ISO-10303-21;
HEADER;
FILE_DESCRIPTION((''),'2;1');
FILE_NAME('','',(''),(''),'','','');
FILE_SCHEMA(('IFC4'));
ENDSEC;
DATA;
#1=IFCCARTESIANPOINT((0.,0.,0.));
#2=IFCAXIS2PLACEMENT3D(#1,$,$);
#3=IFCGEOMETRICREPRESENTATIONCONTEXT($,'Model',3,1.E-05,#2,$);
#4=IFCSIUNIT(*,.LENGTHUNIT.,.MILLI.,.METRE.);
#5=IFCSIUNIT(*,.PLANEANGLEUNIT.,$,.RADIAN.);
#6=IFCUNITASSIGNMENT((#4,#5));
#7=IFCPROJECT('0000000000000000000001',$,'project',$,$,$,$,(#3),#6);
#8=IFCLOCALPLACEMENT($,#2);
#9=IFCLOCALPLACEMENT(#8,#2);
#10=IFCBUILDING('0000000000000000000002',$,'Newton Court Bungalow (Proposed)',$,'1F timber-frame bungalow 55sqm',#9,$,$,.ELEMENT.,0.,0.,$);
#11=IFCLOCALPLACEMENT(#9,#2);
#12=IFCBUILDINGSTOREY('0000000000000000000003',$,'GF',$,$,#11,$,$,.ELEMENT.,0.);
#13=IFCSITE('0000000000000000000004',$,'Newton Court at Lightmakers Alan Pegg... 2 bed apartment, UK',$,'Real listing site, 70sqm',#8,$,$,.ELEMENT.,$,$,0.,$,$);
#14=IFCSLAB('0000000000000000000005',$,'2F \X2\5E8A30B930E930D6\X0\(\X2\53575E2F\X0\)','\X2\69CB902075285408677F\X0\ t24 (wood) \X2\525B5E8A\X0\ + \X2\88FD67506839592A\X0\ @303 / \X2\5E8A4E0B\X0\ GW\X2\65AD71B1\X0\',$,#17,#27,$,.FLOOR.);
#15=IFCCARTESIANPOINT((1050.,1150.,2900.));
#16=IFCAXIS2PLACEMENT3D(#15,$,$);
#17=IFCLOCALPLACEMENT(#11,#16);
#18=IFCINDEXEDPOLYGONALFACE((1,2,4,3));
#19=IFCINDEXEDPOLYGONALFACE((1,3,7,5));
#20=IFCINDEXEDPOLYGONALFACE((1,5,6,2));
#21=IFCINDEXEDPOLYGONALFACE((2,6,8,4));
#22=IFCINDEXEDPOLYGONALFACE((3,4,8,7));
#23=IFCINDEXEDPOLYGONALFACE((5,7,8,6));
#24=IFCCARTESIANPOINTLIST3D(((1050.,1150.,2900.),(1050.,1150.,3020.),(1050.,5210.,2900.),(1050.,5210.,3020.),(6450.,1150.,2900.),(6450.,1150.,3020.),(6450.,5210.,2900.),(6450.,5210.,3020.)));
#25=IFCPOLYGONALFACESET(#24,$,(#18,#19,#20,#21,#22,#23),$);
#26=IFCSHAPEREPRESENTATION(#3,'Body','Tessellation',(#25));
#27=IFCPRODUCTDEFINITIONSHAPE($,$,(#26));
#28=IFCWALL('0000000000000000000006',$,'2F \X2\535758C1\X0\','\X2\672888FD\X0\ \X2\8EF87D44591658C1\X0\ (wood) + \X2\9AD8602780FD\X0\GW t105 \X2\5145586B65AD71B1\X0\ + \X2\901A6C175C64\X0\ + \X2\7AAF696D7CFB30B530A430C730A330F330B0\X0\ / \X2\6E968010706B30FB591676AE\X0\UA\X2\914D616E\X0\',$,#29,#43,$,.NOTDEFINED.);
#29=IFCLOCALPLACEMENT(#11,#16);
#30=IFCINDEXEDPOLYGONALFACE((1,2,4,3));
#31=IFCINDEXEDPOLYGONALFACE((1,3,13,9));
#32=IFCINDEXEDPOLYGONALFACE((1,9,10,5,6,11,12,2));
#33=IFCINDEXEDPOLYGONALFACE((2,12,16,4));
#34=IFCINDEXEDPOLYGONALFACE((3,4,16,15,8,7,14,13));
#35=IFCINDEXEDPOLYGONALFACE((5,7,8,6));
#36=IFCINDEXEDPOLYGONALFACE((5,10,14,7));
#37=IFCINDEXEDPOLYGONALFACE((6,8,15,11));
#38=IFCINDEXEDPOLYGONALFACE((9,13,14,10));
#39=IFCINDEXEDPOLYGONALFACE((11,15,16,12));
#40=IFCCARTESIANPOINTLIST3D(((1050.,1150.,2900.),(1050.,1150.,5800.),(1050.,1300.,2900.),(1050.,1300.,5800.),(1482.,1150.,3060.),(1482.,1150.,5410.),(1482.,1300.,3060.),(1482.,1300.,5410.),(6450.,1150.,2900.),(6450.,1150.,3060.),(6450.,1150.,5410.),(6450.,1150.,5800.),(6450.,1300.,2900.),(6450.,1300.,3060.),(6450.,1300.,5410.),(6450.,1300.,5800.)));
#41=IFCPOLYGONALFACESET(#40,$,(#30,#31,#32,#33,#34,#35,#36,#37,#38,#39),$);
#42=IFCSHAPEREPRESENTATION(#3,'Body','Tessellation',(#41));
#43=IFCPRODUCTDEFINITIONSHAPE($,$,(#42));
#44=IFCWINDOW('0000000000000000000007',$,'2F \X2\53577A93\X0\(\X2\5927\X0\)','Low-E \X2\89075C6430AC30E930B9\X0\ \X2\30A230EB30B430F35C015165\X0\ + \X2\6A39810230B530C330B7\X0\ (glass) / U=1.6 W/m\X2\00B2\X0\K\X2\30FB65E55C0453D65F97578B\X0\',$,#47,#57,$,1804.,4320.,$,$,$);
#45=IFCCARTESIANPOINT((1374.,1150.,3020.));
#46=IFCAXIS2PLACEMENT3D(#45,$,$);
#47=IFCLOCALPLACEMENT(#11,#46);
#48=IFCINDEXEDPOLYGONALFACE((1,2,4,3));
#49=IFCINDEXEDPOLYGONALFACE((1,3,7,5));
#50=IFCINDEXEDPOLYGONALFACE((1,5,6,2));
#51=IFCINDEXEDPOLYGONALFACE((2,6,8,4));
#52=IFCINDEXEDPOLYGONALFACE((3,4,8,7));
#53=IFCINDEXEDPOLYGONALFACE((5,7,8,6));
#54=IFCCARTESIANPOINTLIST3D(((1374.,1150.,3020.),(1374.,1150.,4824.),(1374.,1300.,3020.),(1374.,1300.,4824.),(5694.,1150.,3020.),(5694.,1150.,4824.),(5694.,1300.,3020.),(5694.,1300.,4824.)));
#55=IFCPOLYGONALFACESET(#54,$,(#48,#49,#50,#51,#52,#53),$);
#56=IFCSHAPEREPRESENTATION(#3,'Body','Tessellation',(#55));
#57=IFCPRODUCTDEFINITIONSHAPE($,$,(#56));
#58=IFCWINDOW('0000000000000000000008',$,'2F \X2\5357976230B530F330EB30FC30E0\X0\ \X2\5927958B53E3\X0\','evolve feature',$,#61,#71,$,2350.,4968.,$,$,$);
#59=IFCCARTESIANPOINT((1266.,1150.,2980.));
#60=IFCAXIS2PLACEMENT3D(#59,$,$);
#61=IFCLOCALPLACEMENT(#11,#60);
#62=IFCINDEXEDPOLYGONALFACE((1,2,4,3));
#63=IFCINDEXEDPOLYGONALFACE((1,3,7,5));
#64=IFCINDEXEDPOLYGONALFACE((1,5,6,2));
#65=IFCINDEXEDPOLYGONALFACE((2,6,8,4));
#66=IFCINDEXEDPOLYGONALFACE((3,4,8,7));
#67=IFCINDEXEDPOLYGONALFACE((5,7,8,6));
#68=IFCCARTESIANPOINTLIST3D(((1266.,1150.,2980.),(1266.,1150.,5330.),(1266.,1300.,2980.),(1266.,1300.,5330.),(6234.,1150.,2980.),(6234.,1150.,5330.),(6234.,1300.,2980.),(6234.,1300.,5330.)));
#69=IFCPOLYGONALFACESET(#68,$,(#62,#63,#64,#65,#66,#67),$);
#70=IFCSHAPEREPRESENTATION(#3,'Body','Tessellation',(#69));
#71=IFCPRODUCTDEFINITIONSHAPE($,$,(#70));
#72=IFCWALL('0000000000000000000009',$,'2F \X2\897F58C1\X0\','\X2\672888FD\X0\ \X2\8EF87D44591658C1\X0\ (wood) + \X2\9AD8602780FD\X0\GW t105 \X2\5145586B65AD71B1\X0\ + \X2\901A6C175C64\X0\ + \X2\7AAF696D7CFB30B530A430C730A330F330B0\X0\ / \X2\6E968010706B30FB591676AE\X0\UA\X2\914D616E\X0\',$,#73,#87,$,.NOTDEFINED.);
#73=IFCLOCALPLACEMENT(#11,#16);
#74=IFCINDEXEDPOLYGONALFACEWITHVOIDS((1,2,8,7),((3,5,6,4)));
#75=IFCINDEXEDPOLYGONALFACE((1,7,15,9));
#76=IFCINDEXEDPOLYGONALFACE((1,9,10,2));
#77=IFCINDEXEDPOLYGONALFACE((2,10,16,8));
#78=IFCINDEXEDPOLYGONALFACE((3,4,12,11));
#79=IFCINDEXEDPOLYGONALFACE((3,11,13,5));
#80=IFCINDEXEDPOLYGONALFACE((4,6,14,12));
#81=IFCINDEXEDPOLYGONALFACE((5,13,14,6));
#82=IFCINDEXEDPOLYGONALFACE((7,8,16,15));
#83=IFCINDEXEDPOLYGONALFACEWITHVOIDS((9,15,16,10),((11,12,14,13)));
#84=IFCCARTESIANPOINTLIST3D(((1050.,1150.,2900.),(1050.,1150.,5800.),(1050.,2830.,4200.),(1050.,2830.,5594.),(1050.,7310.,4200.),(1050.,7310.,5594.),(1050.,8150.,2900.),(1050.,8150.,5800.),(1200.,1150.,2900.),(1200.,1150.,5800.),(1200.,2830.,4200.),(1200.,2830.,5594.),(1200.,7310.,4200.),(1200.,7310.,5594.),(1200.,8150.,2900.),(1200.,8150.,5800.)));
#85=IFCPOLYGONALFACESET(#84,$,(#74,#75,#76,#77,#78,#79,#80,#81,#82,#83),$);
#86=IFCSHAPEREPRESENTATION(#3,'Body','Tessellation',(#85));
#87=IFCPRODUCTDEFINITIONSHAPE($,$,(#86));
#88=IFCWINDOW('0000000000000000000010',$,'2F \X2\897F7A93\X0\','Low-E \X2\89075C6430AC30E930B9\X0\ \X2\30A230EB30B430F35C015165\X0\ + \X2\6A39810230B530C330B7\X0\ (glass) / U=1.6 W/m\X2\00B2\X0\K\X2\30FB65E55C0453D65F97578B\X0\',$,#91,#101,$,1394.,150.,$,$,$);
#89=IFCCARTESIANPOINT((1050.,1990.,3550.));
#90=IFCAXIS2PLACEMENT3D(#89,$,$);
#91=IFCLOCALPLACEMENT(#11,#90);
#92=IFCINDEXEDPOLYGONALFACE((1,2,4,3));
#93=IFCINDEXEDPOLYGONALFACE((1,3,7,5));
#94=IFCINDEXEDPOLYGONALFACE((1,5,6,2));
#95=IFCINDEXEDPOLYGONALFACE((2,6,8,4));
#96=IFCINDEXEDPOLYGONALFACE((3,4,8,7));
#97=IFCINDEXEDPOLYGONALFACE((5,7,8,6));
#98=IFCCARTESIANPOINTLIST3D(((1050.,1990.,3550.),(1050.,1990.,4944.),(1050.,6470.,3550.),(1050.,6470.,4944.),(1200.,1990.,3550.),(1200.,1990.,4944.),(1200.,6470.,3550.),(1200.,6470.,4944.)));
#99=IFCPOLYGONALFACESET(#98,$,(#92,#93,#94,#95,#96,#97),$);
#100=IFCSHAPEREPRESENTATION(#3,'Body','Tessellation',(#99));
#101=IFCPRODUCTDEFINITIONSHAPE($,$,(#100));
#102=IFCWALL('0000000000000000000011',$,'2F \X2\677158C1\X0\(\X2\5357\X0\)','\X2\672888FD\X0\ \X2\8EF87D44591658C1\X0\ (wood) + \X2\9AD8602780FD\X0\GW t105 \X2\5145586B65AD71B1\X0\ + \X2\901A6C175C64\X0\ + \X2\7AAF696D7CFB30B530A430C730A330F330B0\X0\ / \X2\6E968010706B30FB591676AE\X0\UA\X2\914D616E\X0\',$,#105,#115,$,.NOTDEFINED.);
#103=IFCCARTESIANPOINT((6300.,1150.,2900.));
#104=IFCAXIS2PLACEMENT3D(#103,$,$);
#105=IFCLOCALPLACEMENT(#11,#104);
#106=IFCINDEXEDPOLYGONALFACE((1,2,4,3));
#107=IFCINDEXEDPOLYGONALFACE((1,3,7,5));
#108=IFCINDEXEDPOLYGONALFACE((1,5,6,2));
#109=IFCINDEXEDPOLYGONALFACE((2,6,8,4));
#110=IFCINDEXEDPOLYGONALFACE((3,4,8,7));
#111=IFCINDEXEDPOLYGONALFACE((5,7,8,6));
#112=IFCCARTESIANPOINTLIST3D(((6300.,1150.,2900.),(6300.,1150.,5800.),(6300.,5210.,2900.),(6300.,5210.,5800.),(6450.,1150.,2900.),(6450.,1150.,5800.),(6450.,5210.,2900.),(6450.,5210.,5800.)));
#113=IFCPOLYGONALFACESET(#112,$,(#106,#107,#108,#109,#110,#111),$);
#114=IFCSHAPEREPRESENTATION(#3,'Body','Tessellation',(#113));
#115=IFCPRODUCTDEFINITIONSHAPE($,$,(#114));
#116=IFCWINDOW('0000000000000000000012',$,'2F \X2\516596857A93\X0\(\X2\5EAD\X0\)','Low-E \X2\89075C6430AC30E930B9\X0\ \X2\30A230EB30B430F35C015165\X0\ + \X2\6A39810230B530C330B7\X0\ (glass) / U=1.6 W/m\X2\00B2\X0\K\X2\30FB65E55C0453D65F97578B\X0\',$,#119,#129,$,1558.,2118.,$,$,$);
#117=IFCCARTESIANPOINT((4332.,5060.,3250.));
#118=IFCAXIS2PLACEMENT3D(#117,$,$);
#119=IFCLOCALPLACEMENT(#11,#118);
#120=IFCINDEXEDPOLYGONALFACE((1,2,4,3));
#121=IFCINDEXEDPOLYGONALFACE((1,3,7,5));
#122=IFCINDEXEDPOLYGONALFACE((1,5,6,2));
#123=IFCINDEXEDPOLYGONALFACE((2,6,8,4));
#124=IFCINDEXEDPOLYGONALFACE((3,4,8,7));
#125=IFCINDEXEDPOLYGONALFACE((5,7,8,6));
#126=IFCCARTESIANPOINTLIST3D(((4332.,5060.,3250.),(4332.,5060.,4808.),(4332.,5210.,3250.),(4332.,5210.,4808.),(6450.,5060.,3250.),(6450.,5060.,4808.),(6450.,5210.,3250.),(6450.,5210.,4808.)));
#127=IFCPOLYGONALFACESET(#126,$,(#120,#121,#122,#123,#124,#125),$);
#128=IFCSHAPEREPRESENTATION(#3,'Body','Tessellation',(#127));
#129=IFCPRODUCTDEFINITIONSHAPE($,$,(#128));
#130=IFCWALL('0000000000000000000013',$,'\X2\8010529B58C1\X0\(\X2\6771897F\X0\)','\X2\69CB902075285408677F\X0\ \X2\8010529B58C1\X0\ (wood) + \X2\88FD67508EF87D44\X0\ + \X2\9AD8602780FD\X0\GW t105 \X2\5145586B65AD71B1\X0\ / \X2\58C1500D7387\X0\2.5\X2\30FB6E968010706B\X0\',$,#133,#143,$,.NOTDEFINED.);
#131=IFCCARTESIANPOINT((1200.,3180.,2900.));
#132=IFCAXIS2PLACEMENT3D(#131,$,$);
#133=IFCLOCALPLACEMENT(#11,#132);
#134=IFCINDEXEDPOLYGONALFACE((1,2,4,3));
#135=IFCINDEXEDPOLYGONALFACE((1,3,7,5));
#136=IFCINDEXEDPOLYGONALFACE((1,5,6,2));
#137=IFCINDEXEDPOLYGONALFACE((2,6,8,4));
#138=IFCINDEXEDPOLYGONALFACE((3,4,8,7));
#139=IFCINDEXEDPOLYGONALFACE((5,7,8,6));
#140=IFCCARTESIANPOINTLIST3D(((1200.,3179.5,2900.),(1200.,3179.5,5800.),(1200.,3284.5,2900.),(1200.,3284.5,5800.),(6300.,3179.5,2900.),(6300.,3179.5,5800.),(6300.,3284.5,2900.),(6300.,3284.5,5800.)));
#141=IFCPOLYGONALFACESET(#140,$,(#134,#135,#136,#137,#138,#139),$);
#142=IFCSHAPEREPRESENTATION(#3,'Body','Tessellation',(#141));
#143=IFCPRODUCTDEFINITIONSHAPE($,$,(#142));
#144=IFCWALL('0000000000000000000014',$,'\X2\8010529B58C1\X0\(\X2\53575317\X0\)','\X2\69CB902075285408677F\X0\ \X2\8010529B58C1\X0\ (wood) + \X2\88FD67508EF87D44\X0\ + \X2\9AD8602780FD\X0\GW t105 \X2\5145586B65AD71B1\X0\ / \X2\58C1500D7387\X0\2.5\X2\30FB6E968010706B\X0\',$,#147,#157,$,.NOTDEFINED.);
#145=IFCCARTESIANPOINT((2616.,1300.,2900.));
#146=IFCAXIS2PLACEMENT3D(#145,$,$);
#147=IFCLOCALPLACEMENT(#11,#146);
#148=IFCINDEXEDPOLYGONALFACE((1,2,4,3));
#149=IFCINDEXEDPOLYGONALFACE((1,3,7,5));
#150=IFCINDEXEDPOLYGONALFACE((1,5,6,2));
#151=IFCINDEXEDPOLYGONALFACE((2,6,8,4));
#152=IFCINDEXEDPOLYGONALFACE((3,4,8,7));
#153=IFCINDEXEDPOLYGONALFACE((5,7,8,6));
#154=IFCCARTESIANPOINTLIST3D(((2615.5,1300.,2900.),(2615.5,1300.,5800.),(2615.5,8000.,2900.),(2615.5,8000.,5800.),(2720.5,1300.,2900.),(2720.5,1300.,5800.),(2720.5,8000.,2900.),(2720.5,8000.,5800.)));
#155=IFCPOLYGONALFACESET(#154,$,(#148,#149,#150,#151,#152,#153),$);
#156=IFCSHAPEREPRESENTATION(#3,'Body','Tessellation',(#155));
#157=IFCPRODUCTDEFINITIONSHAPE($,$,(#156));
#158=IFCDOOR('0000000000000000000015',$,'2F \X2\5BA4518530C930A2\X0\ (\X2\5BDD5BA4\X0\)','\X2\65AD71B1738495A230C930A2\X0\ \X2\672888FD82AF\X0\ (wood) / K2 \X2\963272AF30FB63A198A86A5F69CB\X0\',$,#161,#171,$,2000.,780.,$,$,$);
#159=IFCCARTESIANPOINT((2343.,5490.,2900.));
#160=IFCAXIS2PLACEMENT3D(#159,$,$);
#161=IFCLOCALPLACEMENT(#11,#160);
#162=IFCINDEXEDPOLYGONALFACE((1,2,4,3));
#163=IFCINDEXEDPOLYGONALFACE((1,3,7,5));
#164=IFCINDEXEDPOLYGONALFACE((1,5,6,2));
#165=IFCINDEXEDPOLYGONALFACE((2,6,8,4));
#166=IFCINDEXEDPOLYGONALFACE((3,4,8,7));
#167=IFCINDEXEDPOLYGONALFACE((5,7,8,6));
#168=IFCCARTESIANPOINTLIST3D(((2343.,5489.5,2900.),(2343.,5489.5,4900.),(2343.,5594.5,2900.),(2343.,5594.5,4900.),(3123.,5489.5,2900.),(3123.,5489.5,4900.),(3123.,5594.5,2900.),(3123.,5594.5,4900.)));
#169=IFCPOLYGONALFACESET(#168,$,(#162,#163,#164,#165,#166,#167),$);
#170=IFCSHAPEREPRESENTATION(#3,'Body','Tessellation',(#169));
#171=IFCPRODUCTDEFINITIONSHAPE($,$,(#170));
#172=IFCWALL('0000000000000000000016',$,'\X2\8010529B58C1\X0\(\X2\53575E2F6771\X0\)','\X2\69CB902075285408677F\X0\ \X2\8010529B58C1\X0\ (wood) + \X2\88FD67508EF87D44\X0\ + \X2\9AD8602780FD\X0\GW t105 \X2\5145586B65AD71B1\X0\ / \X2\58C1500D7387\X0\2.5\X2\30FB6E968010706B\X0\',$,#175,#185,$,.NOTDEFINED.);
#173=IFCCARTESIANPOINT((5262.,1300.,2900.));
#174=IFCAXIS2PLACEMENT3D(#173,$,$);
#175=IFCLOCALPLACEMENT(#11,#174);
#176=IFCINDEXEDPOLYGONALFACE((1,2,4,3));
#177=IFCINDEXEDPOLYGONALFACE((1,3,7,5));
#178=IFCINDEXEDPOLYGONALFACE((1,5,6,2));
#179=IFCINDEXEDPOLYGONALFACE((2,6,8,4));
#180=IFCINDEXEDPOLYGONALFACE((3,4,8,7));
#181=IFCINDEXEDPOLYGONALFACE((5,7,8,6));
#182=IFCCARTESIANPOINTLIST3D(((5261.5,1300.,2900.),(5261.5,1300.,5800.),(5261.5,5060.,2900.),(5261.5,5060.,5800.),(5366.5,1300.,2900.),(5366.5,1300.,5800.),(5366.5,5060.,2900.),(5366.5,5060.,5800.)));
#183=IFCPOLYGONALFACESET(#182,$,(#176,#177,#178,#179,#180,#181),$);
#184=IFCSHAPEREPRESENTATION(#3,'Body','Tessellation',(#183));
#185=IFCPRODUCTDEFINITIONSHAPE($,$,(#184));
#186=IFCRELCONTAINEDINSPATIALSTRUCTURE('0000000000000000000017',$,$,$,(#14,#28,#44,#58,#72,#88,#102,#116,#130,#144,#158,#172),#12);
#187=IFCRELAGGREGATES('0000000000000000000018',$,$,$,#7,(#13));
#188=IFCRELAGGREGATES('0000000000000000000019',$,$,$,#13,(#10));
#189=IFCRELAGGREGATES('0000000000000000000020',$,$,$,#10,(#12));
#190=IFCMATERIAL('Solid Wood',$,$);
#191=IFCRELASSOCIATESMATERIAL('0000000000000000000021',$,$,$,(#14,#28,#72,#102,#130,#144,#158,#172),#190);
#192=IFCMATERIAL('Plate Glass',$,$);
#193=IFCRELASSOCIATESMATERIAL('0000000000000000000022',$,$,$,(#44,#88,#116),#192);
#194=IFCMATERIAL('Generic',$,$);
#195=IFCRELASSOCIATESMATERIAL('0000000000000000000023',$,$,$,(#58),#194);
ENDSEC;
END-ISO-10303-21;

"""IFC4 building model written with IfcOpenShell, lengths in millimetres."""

from ifc_helpers import new_model, si_unit, frame, frame_2d, origin, place, context, project, spatial, rectangle, extrude, material, element, fill, save


model = new_model("IFC4")

# Units and contexts
model_context = context("Model", 3, precision=1e-05, world=origin())
ifc_project = project(units=[si_unit("LENGTHUNIT", "METRE", prefix="MILLI"), si_unit("PLANEANGLEUNIT", "RADIAN")], contexts=[model_context])

# Site, building, storey
site_placement = place(None, origin())
site = spatial("IfcSite", under=ifc_project, at=site_placement, Name="Newton Court at Lightmakers Alan Pegg... 2 bed apartment, UK", ObjectType="Real listing site, 70sqm", CompositionType="ELEMENT", RefElevation=0.0)
building_placement = place(site_placement, origin())
building = spatial("IfcBuilding", under=site, at=building_placement, Name="Newton Court Bungalow (Proposed)", ObjectType="1F timber-frame bungalow 55sqm", CompositionType="ELEMENT", ElevationOfRefHeight=0.0, ElevationOfTerrain=0.0)
storey_placement = place(building_placement, origin())
storey = spatial("IfcBuildingStorey", under=building, at=storey_placement, Name="GF", CompositionType="ELEMENT", Elevation=0.0)

# Slab
ifc_material_1 = material(Name="Solid Wood")
slab_placement = place(storey_placement, frame((1050.0, 1150.0, 2900.0)))
element("IfcSlab", 1, at=slab_placement, inside=storey, material=ifc_material_1, Name="2F 床スラブ(南帯)", Description="構造用合板 t24 (wood) 剛床 + 製材根太 @303 / 床下 GW断熱", PredefinedType="FLOOR", context=model_context, shape_type="SweptSolid", body=[
    extrude(rectangle(XDim=5400.0, YDim=4060.0, at=frame_2d((2700.0, 2030.0))), frame((1050.0, 1150.0, 2900.0)), (0.0, 0.0, 1.0), 120.0),
])

# Wall, openings, windows
wall_1_placement = place(storey_placement, frame((1050.0, 1150.0, 2900.0)))
wall_1 = element("IfcWall", 2, at=wall_1_placement, inside=storey, material=ifc_material_1, Name="2F 南壁", Description="木製 軸組外壁 (wood) + 高性能GW t105 充填断熱 + 通気層 + 窯業系サイディング / 準耐火・外皮UA配慮", PredefinedType="NOTDEFINED", context=model_context, shape_type="SweptSolid", body=[
    extrude(rectangle(XDim=5400.0, YDim=150.0, at=frame_2d((2700.0, 75.0))), frame((1050.0, 1150.0, 2900.0)), (0.0, 0.0, 1.0), 2900.0),
])
opening_1_placement = place(storey_placement, frame((1374.0, 1150.0, 3020.0)))
opening_1 = element("IfcOpeningElement", 3, at=opening_1_placement, cuts=wall_1, PredefinedType="NOTDEFINED", context=model_context, shape_type="SweptSolid", body=[
    extrude(rectangle(XDim=4320.0, YDim=150.0, at=frame_2d((2160.0, 75.0))), frame((1374.0, 1150.0, 3020.0)), (0.0, 0.0, 1.0), 1804.0),
])
opening_2_placement = place(storey_placement, frame((1266.0, 1150.0, 2980.0)))
opening_2 = element("IfcOpeningElement", 4, at=opening_2_placement, cuts=wall_1, PredefinedType="NOTDEFINED", context=model_context, shape_type="SweptSolid", body=[
    extrude(rectangle(XDim=4968.0, YDim=150.0, at=frame_2d((2484.0, 75.0))), frame((1266.0, 1150.0, 2980.0)), (0.0, 0.0, 1.0), 2350.0),
])
ifc_material_2 = material(Name="Plate Glass")
window_1_placement = place(storey_placement, frame((1374.0, 1150.0, 3020.0)))
window_1 = element("IfcWindow", 5, at=window_1_placement, inside=storey, material=ifc_material_2, Name="2F 南窓(大)", Description="Low-E 複層ガラス アルゴン封入 + 樹脂サッシ (glass) / U=1.6 W/m²K・日射取得型", OverallHeight=1804.0, OverallWidth=4320.0, context=model_context, shape_type="SweptSolid", body=[
    extrude(rectangle(XDim=4320.0, YDim=150.0, at=frame_2d((2160.0, 75.0))), frame((1374.0, 1150.0, 3020.0)), (0.0, 0.0, 1.0), 1804.0),
])
fill(opening_1, window_1)
ifc_material_3 = material(Name="Generic")
window_2_placement = place(storey_placement, frame((1266.0, 1150.0, 2980.0)))
window_2 = element("IfcWindow", 6, at=window_2_placement, inside=storey, material=ifc_material_3, Name="2F 南面サンルーム 大開口", Description="evolve feature", OverallHeight=2350.0, OverallWidth=4968.0, context=model_context, shape_type="SweptSolid", body=[
    extrude(rectangle(XDim=4968.0, YDim=150.0, at=frame_2d((2484.0, 75.0))), frame((1266.0, 1150.0, 2980.0)), (0.0, 0.0, 1.0), 2350.0),
])
fill(opening_2, window_2)

# Walls, openings, windows
wall_2_placement = place(storey_placement, frame((1050.0, 1150.0, 2900.0)))
wall_2 = element("IfcWall", 7, at=wall_2_placement, inside=storey, material=ifc_material_1, Name="2F 西壁", Description="木製 軸組外壁 (wood) + 高性能GW t105 充填断熱 + 通気層 + 窯業系サイディング / 準耐火・外皮UA配慮", PredefinedType="NOTDEFINED", context=model_context, shape_type="SweptSolid", body=[
    extrude(rectangle(XDim=150.0, YDim=7000.0, at=frame_2d((75.0, 3500.0))), frame((1050.0, 1150.0, 2900.0)), (0.0, 0.0, 1.0), 2900.0),
])
opening_3_placement = place(storey_placement, frame((1050.0, 1990.0, 3550.0)))
opening_3 = element("IfcOpeningElement", 8, at=opening_3_placement, cuts=wall_2, PredefinedType="NOTDEFINED", context=model_context, shape_type="SweptSolid", body=[
    extrude(rectangle(XDim=150.0, YDim=4480.0, at=frame_2d((75.0, 2240.0))), frame((1050.0, 1990.0, 3550.0)), (0.0, 0.0, 1.0), 1394.0),
])
window_3_placement = place(storey_placement, frame((1050.0, 1990.0, 3550.0)))
window_3 = element("IfcWindow", 9, at=window_3_placement, inside=storey, material=ifc_material_2, Name="2F 西窓", Description="Low-E 複層ガラス アルゴン封入 + 樹脂サッシ (glass) / U=1.6 W/m²K・日射取得型", OverallHeight=1394.0, OverallWidth=150.0, context=model_context, shape_type="SweptSolid", body=[
    extrude(rectangle(XDim=150.0, YDim=4480.0, at=frame_2d((75.0, 2240.0))), frame((1050.0, 1990.0, 3550.0)), (0.0, 0.0, 1.0), 1394.0),
])
fill(opening_3, window_3)
wall_3_placement = place(storey_placement, frame((6300.0, 1150.0, 2900.0)))
wall_3 = element("IfcWall", 10, at=wall_3_placement, inside=storey, material=ifc_material_1, Name="2F 東壁(南)", Description="木製 軸組外壁 (wood) + 高性能GW t105 充填断熱 + 通気層 + 窯業系サイディング / 準耐火・外皮UA配慮", PredefinedType="NOTDEFINED", context=model_context, shape_type="SweptSolid", body=[
    extrude(rectangle(XDim=150.0, YDim=4060.0, at=frame_2d((75.0, 2030.0))), frame((6300.0, 1150.0, 2900.0)), (0.0, 0.0, 1.0), 2900.0),
])
opening_4_placement = place(storey_placement, frame((4332.0, 5060.0, 3250.0)))
opening_4 = element("IfcOpeningElement", 11, at=opening_4_placement, cuts=wall_3, PredefinedType="NOTDEFINED", context=model_context, shape_type="SweptSolid", body=[
    extrude(rectangle(XDim=2118.0, YDim=150.0, at=frame_2d((1059.0, 75.0))), frame((4332.0, 5060.0, 3250.0)), (0.0, 0.0, 1.0), 1558.0),
])
window_4_placement = place(storey_placement, frame((4332.0, 5060.0, 3250.0)))
window_4 = element("IfcWindow", 12, at=window_4_placement, inside=storey, material=ifc_material_2, Name="2F 入隅窓(庭)", Description="Low-E 複層ガラス アルゴン封入 + 樹脂サッシ (glass) / U=1.6 W/m²K・日射取得型", OverallHeight=1558.0, OverallWidth=2118.0, context=model_context, shape_type="SweptSolid", body=[
    extrude(rectangle(XDim=2118.0, YDim=150.0, at=frame_2d((1059.0, 75.0))), frame((4332.0, 5060.0, 3250.0)), (0.0, 0.0, 1.0), 1558.0),
])
fill(opening_4, window_4)

# Wall
wall_4_placement = place(storey_placement, frame((1200.0, 3180.0, 2900.0)))
element("IfcWall", 13, at=wall_4_placement, inside=storey, material=ifc_material_1, Name="耐力壁(東西)", Description="構造用合板 耐力壁 (wood) + 製材軸組 + 高性能GW t105 充填断熱 / 壁倍率2.5・準耐火", PredefinedType="NOTDEFINED", context=model_context, shape_type="SweptSolid", body=[
    extrude(rectangle(XDim=5100.0, YDim=105.0, at=frame_2d((2550.0, 52.0))), frame((1200.0, 3180.0, 2900.0)), (0.0, 0.0, 1.0), 2900.0),
])

# Wall, opening, door
wall_5_placement = place(storey_placement, frame((2616.0, 1300.0, 2900.0)))
wall_5 = element("IfcWall", 14, at=wall_5_placement, inside=storey, material=ifc_material_1, Name="耐力壁(南北)", Description="構造用合板 耐力壁 (wood) + 製材軸組 + 高性能GW t105 充填断熱 / 壁倍率2.5・準耐火", PredefinedType="NOTDEFINED", context=model_context, shape_type="SweptSolid", body=[
    extrude(rectangle(XDim=105.0, YDim=6700.0, at=frame_2d((52.0, 3350.0))), frame((2616.0, 1300.0, 2900.0)), (0.0, 0.0, 1.0), 2900.0),
])
opening_5_placement = place(storey_placement, frame((2343.0, 5490.0, 2900.0)))
opening_5 = element("IfcOpeningElement", 15, at=opening_5_placement, cuts=wall_5, PredefinedType="NOTDEFINED", context=model_context, shape_type="SweptSolid", body=[
    extrude(rectangle(XDim=780.0, YDim=105.0, at=frame_2d((390.0, 52.0))), frame((2343.0, 5490.0, 2900.0)), (0.0, 0.0, 1.0), 2000.0),
])
door_placement = place(storey_placement, frame((2343.0, 5490.0, 2900.0)))
door = element("IfcDoor", 16, at=door_placement, inside=storey, material=ifc_material_1, Name="2F 室内ドア (寝室)", Description="断熱玄関ドア 木製芯 (wood) / K2 防犯・採風機構", OverallHeight=2000.0, OverallWidth=780.0, context=model_context, shape_type="SweptSolid", body=[
    extrude(rectangle(XDim=780.0, YDim=105.0, at=frame_2d((390.0, 52.0))), frame((2343.0, 5490.0, 2900.0)), (0.0, 0.0, 1.0), 2000.0),
])
fill(opening_5, door)

# Wall
wall_6_placement = place(storey_placement, frame((5262.0, 1300.0, 2900.0)))
element("IfcWall", 17, at=wall_6_placement, inside=storey, material=ifc_material_1, Name="耐力壁(南帯東)", Description="構造用合板 耐力壁 (wood) + 製材軸組 + 高性能GW t105 充填断熱 / 壁倍率2.5・準耐火", PredefinedType="NOTDEFINED", context=model_context, shape_type="SweptSolid", body=[
    extrude(rectangle(XDim=105.0, YDim=3760.0, at=frame_2d((52.0, 1880.0))), frame((5262.0, 1300.0, 2900.0)), (0.0, 0.0, 1.0), 2900.0),
])

save(model, "model.ifc")
